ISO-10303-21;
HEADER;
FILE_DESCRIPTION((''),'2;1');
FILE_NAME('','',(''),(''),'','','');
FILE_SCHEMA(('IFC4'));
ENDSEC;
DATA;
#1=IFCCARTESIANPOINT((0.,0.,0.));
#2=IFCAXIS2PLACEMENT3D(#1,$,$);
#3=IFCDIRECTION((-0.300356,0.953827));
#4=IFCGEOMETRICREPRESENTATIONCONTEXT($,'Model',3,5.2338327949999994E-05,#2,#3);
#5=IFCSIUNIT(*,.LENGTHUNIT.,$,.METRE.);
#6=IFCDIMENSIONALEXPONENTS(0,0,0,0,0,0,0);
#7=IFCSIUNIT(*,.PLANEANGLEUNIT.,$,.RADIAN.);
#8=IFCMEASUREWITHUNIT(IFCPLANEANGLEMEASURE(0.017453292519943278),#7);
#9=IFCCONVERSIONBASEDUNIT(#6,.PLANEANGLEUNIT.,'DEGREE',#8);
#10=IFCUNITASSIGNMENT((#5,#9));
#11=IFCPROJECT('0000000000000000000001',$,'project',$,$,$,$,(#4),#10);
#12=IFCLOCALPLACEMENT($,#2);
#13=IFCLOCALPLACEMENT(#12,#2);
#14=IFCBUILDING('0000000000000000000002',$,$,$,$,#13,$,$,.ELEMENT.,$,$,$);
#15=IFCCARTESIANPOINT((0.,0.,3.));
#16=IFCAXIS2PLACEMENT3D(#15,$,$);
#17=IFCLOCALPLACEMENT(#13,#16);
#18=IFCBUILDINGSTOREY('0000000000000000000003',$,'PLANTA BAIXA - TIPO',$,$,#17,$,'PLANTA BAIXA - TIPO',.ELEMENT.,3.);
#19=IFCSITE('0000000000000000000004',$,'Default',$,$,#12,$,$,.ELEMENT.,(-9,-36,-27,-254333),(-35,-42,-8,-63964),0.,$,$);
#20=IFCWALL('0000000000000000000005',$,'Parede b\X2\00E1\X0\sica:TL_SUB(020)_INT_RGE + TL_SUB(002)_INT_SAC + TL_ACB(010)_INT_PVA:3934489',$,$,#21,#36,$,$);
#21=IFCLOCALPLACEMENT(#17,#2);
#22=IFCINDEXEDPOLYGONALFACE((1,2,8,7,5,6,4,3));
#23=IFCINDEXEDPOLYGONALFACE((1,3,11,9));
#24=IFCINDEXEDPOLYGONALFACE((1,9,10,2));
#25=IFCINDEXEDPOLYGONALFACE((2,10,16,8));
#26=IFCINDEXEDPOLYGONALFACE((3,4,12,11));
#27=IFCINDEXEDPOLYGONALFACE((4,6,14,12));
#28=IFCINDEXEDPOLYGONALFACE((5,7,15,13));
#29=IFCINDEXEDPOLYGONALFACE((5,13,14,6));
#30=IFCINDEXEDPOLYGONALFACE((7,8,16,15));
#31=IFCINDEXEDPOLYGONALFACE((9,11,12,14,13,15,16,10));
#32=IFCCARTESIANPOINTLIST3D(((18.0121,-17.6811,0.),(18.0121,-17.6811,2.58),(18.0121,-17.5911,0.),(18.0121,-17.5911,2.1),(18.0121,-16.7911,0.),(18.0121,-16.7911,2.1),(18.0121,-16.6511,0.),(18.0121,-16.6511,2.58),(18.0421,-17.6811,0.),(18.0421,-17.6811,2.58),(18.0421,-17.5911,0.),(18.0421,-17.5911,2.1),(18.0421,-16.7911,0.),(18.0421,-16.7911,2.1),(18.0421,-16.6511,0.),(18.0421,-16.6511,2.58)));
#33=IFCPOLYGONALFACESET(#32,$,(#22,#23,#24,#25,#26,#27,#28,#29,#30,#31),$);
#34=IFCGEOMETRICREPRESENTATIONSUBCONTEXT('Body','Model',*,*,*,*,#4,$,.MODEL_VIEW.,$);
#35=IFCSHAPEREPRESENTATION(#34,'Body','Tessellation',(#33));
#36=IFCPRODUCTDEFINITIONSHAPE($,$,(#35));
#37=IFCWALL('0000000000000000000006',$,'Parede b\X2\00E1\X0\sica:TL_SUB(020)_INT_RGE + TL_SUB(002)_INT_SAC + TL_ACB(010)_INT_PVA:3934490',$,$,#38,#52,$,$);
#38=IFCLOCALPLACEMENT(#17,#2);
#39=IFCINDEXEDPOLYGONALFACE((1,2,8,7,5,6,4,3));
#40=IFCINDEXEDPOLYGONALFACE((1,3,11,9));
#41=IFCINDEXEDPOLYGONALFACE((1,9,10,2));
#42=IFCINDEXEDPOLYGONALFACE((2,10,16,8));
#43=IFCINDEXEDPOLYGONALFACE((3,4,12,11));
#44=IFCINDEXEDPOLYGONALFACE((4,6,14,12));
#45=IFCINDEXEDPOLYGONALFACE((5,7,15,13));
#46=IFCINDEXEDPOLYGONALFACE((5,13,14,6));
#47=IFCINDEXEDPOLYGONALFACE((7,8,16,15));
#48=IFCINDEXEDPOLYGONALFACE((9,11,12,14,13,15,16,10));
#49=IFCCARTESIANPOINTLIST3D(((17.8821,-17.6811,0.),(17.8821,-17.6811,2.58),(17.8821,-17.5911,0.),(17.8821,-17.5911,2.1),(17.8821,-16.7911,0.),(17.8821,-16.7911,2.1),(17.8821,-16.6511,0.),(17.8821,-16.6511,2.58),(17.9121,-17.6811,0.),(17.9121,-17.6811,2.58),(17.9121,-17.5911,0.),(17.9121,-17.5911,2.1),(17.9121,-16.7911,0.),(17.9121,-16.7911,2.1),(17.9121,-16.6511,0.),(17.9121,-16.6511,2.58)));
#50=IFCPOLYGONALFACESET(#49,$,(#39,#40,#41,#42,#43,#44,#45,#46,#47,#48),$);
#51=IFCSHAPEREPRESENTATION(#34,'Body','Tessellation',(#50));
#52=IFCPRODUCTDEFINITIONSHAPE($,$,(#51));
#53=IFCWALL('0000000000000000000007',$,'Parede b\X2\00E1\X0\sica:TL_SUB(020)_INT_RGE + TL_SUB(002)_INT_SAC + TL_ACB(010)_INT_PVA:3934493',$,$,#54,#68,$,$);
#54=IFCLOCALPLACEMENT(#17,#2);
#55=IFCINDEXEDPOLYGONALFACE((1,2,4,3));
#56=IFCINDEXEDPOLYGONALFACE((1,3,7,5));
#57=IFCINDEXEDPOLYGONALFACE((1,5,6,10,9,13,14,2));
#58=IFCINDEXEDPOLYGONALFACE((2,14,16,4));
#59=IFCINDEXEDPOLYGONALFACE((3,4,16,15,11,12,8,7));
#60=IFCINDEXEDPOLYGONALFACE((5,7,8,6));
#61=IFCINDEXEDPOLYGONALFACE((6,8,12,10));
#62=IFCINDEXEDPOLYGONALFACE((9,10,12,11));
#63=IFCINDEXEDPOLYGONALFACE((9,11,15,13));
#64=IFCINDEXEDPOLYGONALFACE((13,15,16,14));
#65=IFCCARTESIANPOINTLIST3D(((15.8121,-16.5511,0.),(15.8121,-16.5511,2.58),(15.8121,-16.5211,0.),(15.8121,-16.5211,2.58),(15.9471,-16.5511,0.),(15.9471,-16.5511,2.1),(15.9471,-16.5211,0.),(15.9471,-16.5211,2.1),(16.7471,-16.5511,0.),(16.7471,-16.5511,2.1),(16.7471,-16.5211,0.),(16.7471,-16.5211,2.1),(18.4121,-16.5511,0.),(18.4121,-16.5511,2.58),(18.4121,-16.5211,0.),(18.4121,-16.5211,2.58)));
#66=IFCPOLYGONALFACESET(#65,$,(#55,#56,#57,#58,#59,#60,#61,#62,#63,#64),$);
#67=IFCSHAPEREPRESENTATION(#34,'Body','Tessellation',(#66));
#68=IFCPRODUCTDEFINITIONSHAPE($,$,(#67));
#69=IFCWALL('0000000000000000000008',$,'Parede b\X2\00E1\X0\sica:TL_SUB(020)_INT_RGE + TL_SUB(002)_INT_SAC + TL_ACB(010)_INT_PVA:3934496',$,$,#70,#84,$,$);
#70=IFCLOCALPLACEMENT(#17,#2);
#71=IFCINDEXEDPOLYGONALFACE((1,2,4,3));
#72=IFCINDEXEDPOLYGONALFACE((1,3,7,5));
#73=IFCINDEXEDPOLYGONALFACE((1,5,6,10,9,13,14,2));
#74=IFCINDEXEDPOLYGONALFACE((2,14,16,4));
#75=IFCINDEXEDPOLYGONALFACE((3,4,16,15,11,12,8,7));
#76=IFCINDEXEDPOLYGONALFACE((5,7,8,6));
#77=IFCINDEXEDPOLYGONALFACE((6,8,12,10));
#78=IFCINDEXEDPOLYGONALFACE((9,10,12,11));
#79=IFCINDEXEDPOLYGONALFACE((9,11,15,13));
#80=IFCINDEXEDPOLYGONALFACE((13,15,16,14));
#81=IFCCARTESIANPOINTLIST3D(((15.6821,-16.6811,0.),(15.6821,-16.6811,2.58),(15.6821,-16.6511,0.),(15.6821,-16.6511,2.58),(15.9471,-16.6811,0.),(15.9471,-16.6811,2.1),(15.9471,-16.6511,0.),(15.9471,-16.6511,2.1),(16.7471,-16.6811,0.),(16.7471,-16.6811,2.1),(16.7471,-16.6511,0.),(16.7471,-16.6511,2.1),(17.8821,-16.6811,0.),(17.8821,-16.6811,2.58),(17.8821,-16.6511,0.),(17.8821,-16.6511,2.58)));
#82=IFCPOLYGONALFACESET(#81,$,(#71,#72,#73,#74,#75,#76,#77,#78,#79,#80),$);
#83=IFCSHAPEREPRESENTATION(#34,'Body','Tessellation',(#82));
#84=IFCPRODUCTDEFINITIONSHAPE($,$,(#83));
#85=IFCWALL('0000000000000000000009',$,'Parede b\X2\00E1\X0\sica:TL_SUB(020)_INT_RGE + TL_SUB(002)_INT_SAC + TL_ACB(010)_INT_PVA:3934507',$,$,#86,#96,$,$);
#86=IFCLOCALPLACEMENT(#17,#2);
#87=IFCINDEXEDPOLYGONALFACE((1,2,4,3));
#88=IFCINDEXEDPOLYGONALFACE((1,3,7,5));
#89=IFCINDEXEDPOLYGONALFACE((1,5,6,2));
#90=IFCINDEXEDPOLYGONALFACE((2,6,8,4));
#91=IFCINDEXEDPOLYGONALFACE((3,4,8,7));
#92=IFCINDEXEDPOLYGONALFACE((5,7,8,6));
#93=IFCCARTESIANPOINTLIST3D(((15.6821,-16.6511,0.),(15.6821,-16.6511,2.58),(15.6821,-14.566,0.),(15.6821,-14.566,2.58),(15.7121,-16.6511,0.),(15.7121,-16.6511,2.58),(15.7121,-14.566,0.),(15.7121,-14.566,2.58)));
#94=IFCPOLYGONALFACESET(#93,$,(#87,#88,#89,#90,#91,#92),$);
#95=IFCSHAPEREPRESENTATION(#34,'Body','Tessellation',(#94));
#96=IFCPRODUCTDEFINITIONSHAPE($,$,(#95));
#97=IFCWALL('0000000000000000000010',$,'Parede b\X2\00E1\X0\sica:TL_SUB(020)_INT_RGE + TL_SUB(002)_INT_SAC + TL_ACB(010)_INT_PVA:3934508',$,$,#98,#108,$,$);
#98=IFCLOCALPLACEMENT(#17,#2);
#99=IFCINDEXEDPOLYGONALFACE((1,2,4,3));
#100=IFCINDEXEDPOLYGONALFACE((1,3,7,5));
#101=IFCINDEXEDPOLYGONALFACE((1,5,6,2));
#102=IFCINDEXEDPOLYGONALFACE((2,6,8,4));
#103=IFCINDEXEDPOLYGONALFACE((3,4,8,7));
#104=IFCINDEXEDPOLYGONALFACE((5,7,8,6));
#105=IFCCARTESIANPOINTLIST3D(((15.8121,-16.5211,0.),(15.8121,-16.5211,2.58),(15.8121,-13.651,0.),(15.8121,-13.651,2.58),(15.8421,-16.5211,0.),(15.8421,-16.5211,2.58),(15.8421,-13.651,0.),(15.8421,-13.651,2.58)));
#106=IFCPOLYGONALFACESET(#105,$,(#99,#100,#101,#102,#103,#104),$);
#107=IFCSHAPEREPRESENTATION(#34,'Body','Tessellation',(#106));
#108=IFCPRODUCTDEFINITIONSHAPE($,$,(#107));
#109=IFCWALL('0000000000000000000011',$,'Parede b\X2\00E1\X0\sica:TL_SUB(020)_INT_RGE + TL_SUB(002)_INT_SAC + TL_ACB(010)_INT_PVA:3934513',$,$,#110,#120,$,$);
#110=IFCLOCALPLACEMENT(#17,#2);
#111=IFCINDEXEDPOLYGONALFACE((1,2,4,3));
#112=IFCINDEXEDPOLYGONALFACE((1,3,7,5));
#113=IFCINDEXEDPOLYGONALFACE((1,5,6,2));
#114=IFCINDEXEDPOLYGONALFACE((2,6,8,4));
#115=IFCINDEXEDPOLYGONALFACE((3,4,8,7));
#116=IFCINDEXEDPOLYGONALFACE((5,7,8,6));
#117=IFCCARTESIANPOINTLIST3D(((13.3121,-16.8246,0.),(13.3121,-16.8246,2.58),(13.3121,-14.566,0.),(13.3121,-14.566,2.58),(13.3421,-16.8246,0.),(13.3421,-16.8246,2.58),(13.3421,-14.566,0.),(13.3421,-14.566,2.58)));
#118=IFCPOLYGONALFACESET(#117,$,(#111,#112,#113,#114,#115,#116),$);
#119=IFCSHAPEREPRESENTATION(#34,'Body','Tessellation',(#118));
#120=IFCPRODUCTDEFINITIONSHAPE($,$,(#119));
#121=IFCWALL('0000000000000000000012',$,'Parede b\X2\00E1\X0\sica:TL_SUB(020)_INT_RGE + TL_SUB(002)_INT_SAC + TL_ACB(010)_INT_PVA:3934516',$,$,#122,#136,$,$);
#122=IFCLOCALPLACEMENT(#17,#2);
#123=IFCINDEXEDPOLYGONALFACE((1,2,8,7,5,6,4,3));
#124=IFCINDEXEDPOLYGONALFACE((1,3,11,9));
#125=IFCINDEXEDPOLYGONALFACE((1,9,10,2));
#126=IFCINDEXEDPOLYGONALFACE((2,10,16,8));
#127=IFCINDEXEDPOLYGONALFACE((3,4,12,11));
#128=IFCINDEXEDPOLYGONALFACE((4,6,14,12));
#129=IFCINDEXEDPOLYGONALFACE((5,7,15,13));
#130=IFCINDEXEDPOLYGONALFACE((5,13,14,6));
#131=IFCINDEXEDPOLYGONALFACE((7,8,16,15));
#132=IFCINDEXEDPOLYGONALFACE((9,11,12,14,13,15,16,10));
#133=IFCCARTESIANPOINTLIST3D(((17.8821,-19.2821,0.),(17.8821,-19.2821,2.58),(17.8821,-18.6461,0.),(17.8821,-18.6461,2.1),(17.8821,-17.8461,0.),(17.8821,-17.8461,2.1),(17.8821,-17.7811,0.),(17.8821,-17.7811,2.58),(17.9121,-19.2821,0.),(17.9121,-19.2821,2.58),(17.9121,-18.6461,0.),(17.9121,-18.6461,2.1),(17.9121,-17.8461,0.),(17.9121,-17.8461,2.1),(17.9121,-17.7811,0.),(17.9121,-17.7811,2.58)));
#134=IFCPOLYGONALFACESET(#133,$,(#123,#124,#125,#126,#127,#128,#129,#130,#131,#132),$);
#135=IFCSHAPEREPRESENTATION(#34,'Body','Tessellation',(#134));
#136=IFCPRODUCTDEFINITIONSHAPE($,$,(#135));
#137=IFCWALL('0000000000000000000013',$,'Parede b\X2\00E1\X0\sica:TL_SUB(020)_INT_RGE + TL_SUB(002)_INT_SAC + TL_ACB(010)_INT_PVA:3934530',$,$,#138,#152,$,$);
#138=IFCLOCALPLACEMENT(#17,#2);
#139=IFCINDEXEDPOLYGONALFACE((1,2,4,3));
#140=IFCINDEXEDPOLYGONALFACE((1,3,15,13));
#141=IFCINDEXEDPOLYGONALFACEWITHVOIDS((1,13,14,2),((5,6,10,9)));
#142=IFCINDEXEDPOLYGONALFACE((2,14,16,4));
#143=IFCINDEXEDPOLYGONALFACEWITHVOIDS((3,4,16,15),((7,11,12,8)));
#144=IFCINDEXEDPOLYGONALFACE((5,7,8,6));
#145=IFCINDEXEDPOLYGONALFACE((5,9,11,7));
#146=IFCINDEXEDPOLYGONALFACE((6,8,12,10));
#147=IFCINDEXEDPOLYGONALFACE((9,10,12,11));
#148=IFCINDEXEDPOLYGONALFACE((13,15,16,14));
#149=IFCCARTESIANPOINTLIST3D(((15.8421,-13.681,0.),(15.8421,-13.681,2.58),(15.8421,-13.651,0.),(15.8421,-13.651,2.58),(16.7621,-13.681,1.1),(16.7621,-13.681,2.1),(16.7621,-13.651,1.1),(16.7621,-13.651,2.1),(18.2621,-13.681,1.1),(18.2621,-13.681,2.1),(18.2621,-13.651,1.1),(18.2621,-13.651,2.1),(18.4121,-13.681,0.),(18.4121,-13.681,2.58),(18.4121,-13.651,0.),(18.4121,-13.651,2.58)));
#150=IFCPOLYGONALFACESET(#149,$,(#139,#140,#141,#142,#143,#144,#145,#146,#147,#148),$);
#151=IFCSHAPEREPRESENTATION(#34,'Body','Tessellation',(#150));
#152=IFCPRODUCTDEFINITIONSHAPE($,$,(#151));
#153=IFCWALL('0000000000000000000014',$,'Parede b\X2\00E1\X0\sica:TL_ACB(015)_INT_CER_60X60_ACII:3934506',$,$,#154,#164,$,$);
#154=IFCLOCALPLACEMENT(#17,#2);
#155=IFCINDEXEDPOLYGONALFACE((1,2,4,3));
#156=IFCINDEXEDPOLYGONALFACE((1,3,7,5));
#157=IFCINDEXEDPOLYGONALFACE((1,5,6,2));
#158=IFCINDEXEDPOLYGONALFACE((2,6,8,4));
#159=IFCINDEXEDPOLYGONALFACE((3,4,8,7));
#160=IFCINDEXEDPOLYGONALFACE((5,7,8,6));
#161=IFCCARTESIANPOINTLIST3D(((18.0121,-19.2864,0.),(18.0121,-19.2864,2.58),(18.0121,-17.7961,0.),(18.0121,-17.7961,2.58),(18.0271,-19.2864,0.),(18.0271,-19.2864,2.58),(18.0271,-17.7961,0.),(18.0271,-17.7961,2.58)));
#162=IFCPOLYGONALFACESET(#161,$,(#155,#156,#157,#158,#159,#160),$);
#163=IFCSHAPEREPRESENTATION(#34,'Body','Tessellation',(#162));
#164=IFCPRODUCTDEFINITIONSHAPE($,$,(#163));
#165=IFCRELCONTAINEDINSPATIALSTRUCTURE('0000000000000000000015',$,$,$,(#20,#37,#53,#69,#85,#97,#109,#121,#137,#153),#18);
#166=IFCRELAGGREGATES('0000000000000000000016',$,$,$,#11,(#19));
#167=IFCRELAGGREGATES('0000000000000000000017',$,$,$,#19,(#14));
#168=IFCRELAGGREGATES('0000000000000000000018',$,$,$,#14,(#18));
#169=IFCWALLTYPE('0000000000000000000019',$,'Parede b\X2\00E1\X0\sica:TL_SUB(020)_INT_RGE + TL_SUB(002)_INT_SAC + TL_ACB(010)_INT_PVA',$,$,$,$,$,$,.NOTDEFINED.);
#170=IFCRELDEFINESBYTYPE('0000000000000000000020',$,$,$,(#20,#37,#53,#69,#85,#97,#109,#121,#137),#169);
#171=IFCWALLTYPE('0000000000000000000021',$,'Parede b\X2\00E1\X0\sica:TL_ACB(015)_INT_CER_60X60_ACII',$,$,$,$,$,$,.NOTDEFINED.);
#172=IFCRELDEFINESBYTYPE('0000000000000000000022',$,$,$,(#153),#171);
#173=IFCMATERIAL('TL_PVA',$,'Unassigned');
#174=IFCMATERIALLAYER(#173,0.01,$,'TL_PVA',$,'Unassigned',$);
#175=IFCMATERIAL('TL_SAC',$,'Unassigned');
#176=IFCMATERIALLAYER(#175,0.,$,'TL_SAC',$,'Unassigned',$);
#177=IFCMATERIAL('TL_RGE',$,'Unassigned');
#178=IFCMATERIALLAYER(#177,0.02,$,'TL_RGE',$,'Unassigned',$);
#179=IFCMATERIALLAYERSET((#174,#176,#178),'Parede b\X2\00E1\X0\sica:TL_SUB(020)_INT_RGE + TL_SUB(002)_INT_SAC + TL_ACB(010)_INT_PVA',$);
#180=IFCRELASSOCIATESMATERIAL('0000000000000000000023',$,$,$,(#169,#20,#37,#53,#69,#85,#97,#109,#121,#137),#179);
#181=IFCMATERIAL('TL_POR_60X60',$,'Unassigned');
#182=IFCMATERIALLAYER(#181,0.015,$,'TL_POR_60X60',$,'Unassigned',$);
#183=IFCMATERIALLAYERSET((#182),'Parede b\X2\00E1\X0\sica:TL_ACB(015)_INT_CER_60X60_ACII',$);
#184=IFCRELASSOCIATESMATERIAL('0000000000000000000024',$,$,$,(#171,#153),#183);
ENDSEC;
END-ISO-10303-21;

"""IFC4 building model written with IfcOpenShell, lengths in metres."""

from ifc_helpers import new_model, entity, si_unit, converted_unit, direction, frame, frame_2d, origin, place, context, subcontext, project, spatial, rectangle, extrude, material, layer, layer_set, layer_usage, type_object, element, save


model = new_model("IFC4")

# Units and contexts
model_context = context("Model", 3, precision=5.2338327949999994e-05, world=origin(), true_north=direction((-0.300356, 0.953827)))
body_context = subcontext(model_context, "Body", "Model", "MODEL_VIEW")
ifc_project = project(units=[si_unit("LENGTHUNIT", "METRE"), converted_unit("PLANEANGLEUNIT", "DEGREE", entity("IfcPlaneAngleMeasure", 0.017453292519943278), si_unit("PLANEANGLEUNIT", "RADIAN"), dimensions=[0, 0, 0, 0, 0, 0, 0])], contexts=[model_context])

# Site, building, storey
site_placement = place(None, origin())
site = spatial("IfcSite", under=ifc_project, at=site_placement, Name="Default", CompositionType="ELEMENT", RefLatitude=(-9, -36, -27, -254333), RefLongitude=(-35, -42, -8, -63964), RefElevation=0.0)
building_placement = place(site_placement, origin())
building = spatial("IfcBuilding", under=site, at=building_placement, CompositionType="ELEMENT")
storey_placement = place(building_placement, frame((0.0, 0.0, 3.0)))
storey = spatial("IfcBuildingStorey", under=building, at=storey_placement, Name="PLANTA BAIXA - TIPO", LongName="PLANTA BAIXA - TIPO", CompositionType="ELEMENT", Elevation=3.0)

# Walls, openings
ifc_material_1 = material(Name="TL_PVA", Category="Unassigned")
ifc_layer_1 = layer(ifc_material_1, 0.01, Name="TL_PVA", Category="Unassigned")
ifc_material_2 = material(Name="TL_SAC", Category="Unassigned")
ifc_layer_2 = layer(ifc_material_2, 0.0, Name="TL_SAC", Category="Unassigned")
ifc_material_3 = material(Name="TL_RGE", Category="Unassigned")
ifc_layer_3 = layer(ifc_material_3, 0.02, Name="TL_RGE", Category="Unassigned")
ifc_layer_set_1 = layer_set([ifc_layer_1, ifc_layer_2, ifc_layer_3], Name="Parede básica:TL_SUB(020)_INT_RGE + TL_SUB(002)_INT_SAC + TL_ACB(010)_INT_PVA")
ifc_layer_usage_1 = layer_usage(ifc_layer_set_1, "AXIS2", "NEGATIVE", 0.015)
wall_type_1 = type_object("IfcWallType", Name="Parede básica:TL_SUB(020)_INT_RGE + TL_SUB(002)_INT_SAC + TL_ACB(010)_INT_PVA", PredefinedType="NOTDEFINED", material=ifc_layer_set_1)
wall_1_placement = place(storey_placement, frame((18.0271, -16.6511, 0.0), z_axis=(0.0, 0.0, 1.0), x_axis=(0.0, -1.0, 0.0)))
wall_1 = element("IfcWall", 1, at=wall_1_placement, inside=storey, type_object=wall_type_1, material=ifc_layer_usage_1, Name="Parede básica:TL_SUB(020)_INT_RGE + TL_SUB(002)_INT_SAC + TL_ACB(010)_INT_PVA:3934489", context=body_context, shape_type="SweptSolid", body=[
    extrude(rectangle(XDim=1.03, YDim=0.03, at=frame_2d((0.515, 0.0), x_axis=(-1.0, 0.0))), origin(), (0.0, 0.0, 1.0), 2.58),
])
opening_1_placement = place(wall_1_placement, frame((-16.6511, -18.0271, 0.0)))
element("IfcOpeningElement", 2, at=opening_1_placement, cuts=wall_1, PredefinedType="OPENING", context=body_context, shape_type="SweptSolid", body=[
    extrude(rectangle(XDim=2.1, YDim=0.8, at=frame_2d((0.0, 0.0), x_axis=(0.0, 1.0))), frame((17.1911, 16.3881, 1.05), z_axis=(0.0, 1.0, 0.0), x_axis=(-1.0, 0.0, 0.0)), (0.0, 0.0, 1.0), 3.048),
])
ifc_layer_usage_2 = layer_usage(ifc_layer_set_1, "AXIS2", "NEGATIVE", 0.015)
wall_2_placement = place(storey_placement, frame((17.8971, -17.6811, 0.0), z_axis=(0.0, 0.0, 1.0), x_axis=(0.0, 1.0, 0.0)))
wall_2 = element("IfcWall", 3, at=wall_2_placement, inside=storey, type_object=wall_type_1, material=ifc_layer_usage_2, Name="Parede básica:TL_SUB(020)_INT_RGE + TL_SUB(002)_INT_SAC + TL_ACB(010)_INT_PVA:3934490", context=body_context, shape_type="SweptSolid", body=[
    extrude(rectangle(XDim=1.03, YDim=0.03, at=frame_2d((0.515, 0.0), x_axis=(-1.0, 0.0))), origin(), (0.0, 0.0, 1.0), 2.58),
])
opening_2_placement = place(wall_2_placement, frame((17.6811, 17.8971, 0.0)))
element("IfcOpeningElement", 4, at=opening_2_placement, cuts=wall_2, PredefinedType="OPENING", context=body_context, shape_type="SweptSolid", body=[
    extrude(rectangle(XDim=2.1, YDim=0.8, at=frame_2d((0.0, 0.0), x_axis=(1.0, 0.0))), frame((-17.1911, -19.4361, 1.05), z_axis=(0.0, 1.0, 0.0), x_axis=(0.0, 0.0, 1.0)), (0.0, 0.0, 1.0), 3.048),
])
ifc_layer_usage_3 = layer_usage(ifc_layer_set_1, "AXIS2", "NEGATIVE", 0.015)
wall_3_placement = place(storey_placement, frame((15.8121, -16.5361, 0.0)))
wall_3 = element("IfcWall", 5, at=wall_3_placement, inside=storey, type_object=wall_type_1, material=ifc_layer_usage_3, Name="Parede básica:TL_SUB(020)_INT_RGE + TL_SUB(002)_INT_SAC + TL_ACB(010)_INT_PVA:3934493", context=body_context, shape_type="SweptSolid", body=[
    extrude(rectangle(XDim=2.6, YDim=0.03, at=frame_2d((1.3, 0.0), x_axis=(-1.0, 0.0))), origin(), (0.0, 0.0, 1.0), 2.58),
])
opening_3_placement = place(wall_3_placement, frame((-15.8121, 16.5361, 0.0)))
element("IfcOpeningElement", 6, at=opening_3_placement, cuts=wall_3, PredefinedType="OPENING", context=body_context, shape_type="SweptSolid", body=[
    extrude(rectangle(XDim=2.1, YDim=0.8, at=frame_2d((0.0, 0.0), x_axis=(1.0, 0.0))), frame((16.3471, -18.1751, 1.05), z_axis=(0.0, 1.0, 0.0), x_axis=(0.0, 0.0, 1.0)), (0.0, 0.0, 1.0), 3.048),
])
ifc_layer_usage_4 = layer_usage(ifc_layer_set_1, "AXIS2", "NEGATIVE", 0.015)
wall_4_placement = place(storey_placement, frame((17.8821, -16.6661, 0.0), z_axis=(0.0, 0.0, 1.0), x_axis=(-1.0, 0.0, 0.0)))
wall_4 = element("IfcWall", 7, at=wall_4_placement, inside=storey, type_object=wall_type_1, material=ifc_layer_usage_4, Name="Parede básica:TL_SUB(020)_INT_RGE + TL_SUB(002)_INT_SAC + TL_ACB(010)_INT_PVA:3934496", context=body_context, shape_type="SweptSolid", body=[
    extrude(rectangle(XDim=2.2, YDim=0.03, at=frame_2d((1.1, 0.0), x_axis=(-1.0, 0.0))), origin(), (0.0, 0.0, 1.0), 2.58),
])
opening_4_placement = place(wall_4_placement, frame((17.8821, -16.6661, 0.0)))
element("IfcOpeningElement", 8, at=opening_4_placement, cuts=wall_4, PredefinedType="OPENING", context=body_context, shape_type="SweptSolid", body=[
    extrude(rectangle(XDim=2.1, YDim=0.8, at=frame_2d((0.0, 0.0), x_axis=(0.0, 1.0))), frame((-16.3471, 15.1271, 1.05), z_axis=(0.0, 1.0, 0.0), x_axis=(-1.0, 0.0, 0.0)), (0.0, 0.0, 1.0), 3.048),
])

# Walls
ifc_layer_usage_5 = layer_usage(ifc_layer_set_1, "AXIS2", "POSITIVE", -0.015)
wall_5_placement = place(storey_placement, frame((15.6971, -14.566, 0.0), z_axis=(0.0, 0.0, 1.0), x_axis=(0.0, -1.0, 0.0)))
element("IfcWall", 9, at=wall_5_placement, inside=storey, type_object=wall_type_1, material=ifc_layer_usage_5, Name="Parede básica:TL_SUB(020)_INT_RGE + TL_SUB(002)_INT_SAC + TL_ACB(010)_INT_PVA:3934507", context=body_context, shape_type="SweptSolid", body=[
    extrude(rectangle(XDim=2.0851, YDim=0.03, at=frame_2d((1.0426, 0.0), x_axis=(-1.0, 0.0))), origin(), (0.0, 0.0, 1.0), 2.58),
])
ifc_layer_usage_6 = layer_usage(ifc_layer_set_1, "AXIS2", "POSITIVE", -0.015)
wall_6_placement = place(storey_placement, frame((15.8271, -16.5211, 0.0), z_axis=(0.0, 0.0, 1.0), x_axis=(0.0, 1.0, 0.0)))
element("IfcWall", 10, at=wall_6_placement, inside=storey, type_object=wall_type_1, material=ifc_layer_usage_6, Name="Parede básica:TL_SUB(020)_INT_RGE + TL_SUB(002)_INT_SAC + TL_ACB(010)_INT_PVA:3934508", context=body_context, shape_type="SweptSolid", body=[
    extrude(rectangle(XDim=2.8701, YDim=0.03, at=frame_2d((1.4351, 0.0), x_axis=(-1.0, 0.0))), origin(), (0.0, 0.0, 1.0), 2.58),
])
ifc_layer_usage_7 = layer_usage(ifc_layer_set_1, "AXIS2", "POSITIVE", -0.015)
wall_7_placement = place(storey_placement, frame((13.3271, -16.8246, 0.0), z_axis=(0.0, 0.0, 1.0), x_axis=(0.0, 1.0, 0.0)))
element("IfcWall", 11, at=wall_7_placement, inside=storey, type_object=wall_type_1, material=ifc_layer_usage_7, Name="Parede básica:TL_SUB(020)_INT_RGE + TL_SUB(002)_INT_SAC + TL_ACB(010)_INT_PVA:3934513", context=body_context, shape_type="SweptSolid", body=[
    extrude(rectangle(XDim=2.2587, YDim=0.03, at=frame_2d((1.1293, 0.0), x_axis=(-1.0, 0.0))), origin(), (0.0, 0.0, 1.0), 2.58),
])

# Walls, openings
ifc_layer_usage_8 = layer_usage(ifc_layer_set_1, "AXIS2", "POSITIVE", -0.015)
wall_8_placement = place(storey_placement, frame((17.8971, -17.7811, 0.0), z_axis=(0.0, 0.0, 1.0), x_axis=(0.0, -1.0, 0.0)))
wall_8 = element("IfcWall", 12, at=wall_8_placement, inside=storey, type_object=wall_type_1, material=ifc_layer_usage_8, Name="Parede básica:TL_SUB(020)_INT_RGE + TL_SUB(002)_INT_SAC + TL_ACB(010)_INT_PVA:3934516", context=body_context, shape_type="SweptSolid", body=[
    extrude(rectangle(XDim=1.501, YDim=0.03, at=frame_2d((0.7505, 0.0), x_axis=(-1.0, 0.0))), origin(), (0.0, 0.0, 1.0), 2.58),
])
opening_5_placement = place(wall_8_placement, frame((0.065, -0.015, 0.0)))
element("IfcOpeningElement", 13, at=opening_5_placement, cuts=wall_8, PredefinedType="OPENING", context=body_context, shape_type="SweptSolid", body=[
    extrude(rectangle(XDim=2.1, YDim=0.8, at=frame_2d((1.05, 0.4), x_axis=(1.0, 0.0))), frame((0.0, 0.0, 0.0), z_axis=(0.0, 1.0, 0.0), x_axis=(0.0, 0.0, 1.0)), (0.0, 0.0, 1.0), 0.03),
])
ifc_layer_usage_9 = layer_usage(ifc_layer_set_1, "AXIS2", "POSITIVE", -0.015)
wall_9_placement = place(storey_placement, frame((15.8421, -13.666, 0.0)))
wall_9 = element("IfcWall", 14, at=wall_9_placement, inside=storey, type_object=wall_type_1, material=ifc_layer_usage_9, Name="Parede básica:TL_SUB(020)_INT_RGE + TL_SUB(002)_INT_SAC + TL_ACB(010)_INT_PVA:3934530", context=body_context, shape_type="SweptSolid", body=[
    extrude(rectangle(XDim=2.57, YDim=0.03, at=frame_2d((1.285, 0.0), x_axis=(-1.0, 0.0))), origin(), (0.0, 0.0, 1.0), 2.58),
])
opening_6_placement = place(wall_9_placement, frame((-15.8421, 13.666, 1.1)))
element("IfcOpeningElement", 15, at=opening_6_placement, cuts=wall_9, PredefinedType="OPENING", context=body_context, shape_type="SweptSolid", body=[
    extrude(rectangle(XDim=1.0, YDim=1.5, at=frame_2d((0.0, 0.0), x_axis=(0.0, 1.0))), frame((17.5121, -15.175, 0.5), z_axis=(0.0, 1.0, 0.0), x_axis=(1.0, 0.0, 0.0)), (0.0, 0.0, 1.0), 3.048),
])

# Wall
ifc_material_4 = material(Name="TL_POR_60X60", Category="Unassigned")
ifc_layer_4 = layer(ifc_material_4, 0.015, Name="TL_POR_60X60", Category="Unassigned")
ifc_layer_set_2 = layer_set([ifc_layer_4], Name="Parede básica:TL_ACB(015)_INT_CER_60X60_ACII")
ifc_layer_usage_10 = layer_usage(ifc_layer_set_2, "AXIS2", "POSITIVE", -0.0075)
wall_type_2 = type_object("IfcWallType", Name="Parede básica:TL_ACB(015)_INT_CER_60X60_ACII", PredefinedType="NOTDEFINED", material=ifc_layer_set_2)
wall_10_placement = place(storey_placement, frame((18.0196, -19.2864, 0.0), z_axis=(0.0, 0.0, 1.0), x_axis=(0.0, 1.0, 0.0)))
element("IfcWall", 16, at=wall_10_placement, inside=storey, type_object=wall_type_2, material=ifc_layer_usage_10, Name="Parede básica:TL_ACB(015)_INT_CER_60X60_ACII:3934506", context=body_context, shape_type="SweptSolid", body=[
    extrude(rectangle(XDim=1.4902, YDim=0.015, at=frame_2d((0.7451, 0.0), x_axis=(-1.0, 0.0))), origin(), (0.0, 0.0, 1.0), 2.58),
])

save(model, "model.ifc")
